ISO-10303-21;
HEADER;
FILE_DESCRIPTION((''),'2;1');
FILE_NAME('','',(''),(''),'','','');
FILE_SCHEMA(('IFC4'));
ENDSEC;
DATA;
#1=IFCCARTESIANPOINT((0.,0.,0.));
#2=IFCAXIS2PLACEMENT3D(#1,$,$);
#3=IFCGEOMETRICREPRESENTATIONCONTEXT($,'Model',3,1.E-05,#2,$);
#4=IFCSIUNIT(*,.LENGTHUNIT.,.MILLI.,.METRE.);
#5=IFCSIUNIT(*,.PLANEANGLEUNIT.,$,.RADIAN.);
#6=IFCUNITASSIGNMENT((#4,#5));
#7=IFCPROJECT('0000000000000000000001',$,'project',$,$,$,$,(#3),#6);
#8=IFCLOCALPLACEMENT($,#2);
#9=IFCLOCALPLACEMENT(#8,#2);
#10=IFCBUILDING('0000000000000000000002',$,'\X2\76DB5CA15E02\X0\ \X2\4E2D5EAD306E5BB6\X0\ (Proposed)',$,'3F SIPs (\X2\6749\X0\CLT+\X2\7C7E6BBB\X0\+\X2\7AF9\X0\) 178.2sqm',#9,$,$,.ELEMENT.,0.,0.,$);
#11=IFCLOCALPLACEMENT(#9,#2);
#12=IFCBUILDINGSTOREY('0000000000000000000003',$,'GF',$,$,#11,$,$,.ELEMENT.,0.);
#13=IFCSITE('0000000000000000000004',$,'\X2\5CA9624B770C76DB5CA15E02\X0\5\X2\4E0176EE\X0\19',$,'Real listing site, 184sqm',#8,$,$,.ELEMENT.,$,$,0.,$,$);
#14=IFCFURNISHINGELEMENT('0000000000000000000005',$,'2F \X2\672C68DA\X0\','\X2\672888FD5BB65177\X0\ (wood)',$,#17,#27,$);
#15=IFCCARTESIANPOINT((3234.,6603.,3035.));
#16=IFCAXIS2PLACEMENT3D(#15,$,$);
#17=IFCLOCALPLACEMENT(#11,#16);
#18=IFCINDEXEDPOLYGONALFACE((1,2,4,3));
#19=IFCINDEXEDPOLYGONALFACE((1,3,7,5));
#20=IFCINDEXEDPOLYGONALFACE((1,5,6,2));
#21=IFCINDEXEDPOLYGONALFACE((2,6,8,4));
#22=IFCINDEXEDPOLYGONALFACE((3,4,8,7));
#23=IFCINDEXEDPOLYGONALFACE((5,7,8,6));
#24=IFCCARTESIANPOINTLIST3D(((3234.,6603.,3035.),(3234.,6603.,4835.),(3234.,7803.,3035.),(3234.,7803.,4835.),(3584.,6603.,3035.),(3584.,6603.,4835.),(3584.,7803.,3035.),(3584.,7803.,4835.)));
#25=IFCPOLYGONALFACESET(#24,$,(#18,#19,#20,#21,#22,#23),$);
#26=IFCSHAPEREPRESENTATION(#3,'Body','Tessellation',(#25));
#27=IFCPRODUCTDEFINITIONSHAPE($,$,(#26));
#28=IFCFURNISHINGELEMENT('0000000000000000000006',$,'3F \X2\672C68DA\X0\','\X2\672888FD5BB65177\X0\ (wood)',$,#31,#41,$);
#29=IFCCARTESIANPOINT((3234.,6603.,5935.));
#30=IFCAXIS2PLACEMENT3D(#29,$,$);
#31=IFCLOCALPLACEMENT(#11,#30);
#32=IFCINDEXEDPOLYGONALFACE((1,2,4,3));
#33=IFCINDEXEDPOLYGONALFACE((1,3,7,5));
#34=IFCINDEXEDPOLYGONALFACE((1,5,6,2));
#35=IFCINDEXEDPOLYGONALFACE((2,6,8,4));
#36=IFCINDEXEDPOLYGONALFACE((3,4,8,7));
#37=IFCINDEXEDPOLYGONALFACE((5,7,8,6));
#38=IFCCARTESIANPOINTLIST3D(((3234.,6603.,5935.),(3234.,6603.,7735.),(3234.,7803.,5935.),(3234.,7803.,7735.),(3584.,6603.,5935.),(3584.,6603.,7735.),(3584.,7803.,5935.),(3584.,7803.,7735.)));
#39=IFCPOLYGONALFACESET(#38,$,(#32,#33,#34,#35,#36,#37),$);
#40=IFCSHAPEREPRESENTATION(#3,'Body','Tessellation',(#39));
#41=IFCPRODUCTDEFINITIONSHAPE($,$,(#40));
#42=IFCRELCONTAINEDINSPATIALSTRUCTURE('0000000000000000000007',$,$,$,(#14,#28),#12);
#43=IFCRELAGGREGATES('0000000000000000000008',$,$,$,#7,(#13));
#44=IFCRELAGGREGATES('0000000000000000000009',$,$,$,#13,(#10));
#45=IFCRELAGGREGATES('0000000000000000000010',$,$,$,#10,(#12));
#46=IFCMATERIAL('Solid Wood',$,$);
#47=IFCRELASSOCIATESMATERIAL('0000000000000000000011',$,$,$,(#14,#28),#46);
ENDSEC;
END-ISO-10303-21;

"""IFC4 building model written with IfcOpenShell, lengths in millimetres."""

from ifc_helpers import new_model, si_unit, frame, frame_2d, origin, place, context, project, spatial, rectangle, extrude, material, element, save


model = new_model("IFC4")

# Units and contexts
model_context = context("Model", 3, precision=1e-05, world=origin())
ifc_project = project(units=[si_unit("LENGTHUNIT", "METRE", prefix="MILLI"), si_unit("PLANEANGLEUNIT", "RADIAN")], contexts=[model_context])

# Site, building, storey
site_placement = place(None, origin())
site = spatial("IfcSite", under=ifc_project, at=site_placement, Name="岩手県盛岡市5丁目19", ObjectType="Real listing site, 184sqm", CompositionType="ELEMENT", RefElevation=0.0)
building_placement = place(site_placement, origin())
building = spatial("IfcBuilding", under=site, at=building_placement, Name="盛岡市 中庭の家 (Proposed)", ObjectType="3F SIPs (杉CLT+籾殻+竹) 178.2sqm", CompositionType="ELEMENT", ElevationOfRefHeight=0.0, ElevationOfTerrain=0.0)
storey_placement = place(building_placement, origin())
storey = spatial("IfcBuildingStorey", under=building, at=storey_placement, Name="GF", CompositionType="ELEMENT", Elevation=0.0)

# Shared definitions
ifc_material_1 = material(Name="Solid Wood")

# Furnishing elements
furnishing_1_placement = place(storey_placement, frame((3234.0, 6603.0, 3035.0)))
element("IfcFurnishingElement", 1, at=furnishing_1_placement, inside=storey, material=ifc_material_1, Name="2F 本棚", Description="木製家具 (wood)", context=model_context, shape_type="SweptSolid", body=[
    extrude(rectangle(XDim=350.0, YDim=1200.0, at=frame_2d((175.0, 600.0))), frame((3234.0, 6603.0, 3035.0)), (0.0, 0.0, 1.0), 1800.0),
])
furnishing_2_placement = place(storey_placement, frame((3234.0, 6603.0, 5935.0)))
element("IfcFurnishingElement", 2, at=furnishing_2_placement, inside=storey, material=ifc_material_1, Name="3F 本棚", Description="木製家具 (wood)", context=model_context, shape_type="SweptSolid", body=[
    extrude(rectangle(XDim=350.0, YDim=1200.0, at=frame_2d((175.0, 600.0))), frame((3234.0, 6603.0, 5935.0)), (0.0, 0.0, 1.0), 1800.0),
])

save(model, "model.ifc")
